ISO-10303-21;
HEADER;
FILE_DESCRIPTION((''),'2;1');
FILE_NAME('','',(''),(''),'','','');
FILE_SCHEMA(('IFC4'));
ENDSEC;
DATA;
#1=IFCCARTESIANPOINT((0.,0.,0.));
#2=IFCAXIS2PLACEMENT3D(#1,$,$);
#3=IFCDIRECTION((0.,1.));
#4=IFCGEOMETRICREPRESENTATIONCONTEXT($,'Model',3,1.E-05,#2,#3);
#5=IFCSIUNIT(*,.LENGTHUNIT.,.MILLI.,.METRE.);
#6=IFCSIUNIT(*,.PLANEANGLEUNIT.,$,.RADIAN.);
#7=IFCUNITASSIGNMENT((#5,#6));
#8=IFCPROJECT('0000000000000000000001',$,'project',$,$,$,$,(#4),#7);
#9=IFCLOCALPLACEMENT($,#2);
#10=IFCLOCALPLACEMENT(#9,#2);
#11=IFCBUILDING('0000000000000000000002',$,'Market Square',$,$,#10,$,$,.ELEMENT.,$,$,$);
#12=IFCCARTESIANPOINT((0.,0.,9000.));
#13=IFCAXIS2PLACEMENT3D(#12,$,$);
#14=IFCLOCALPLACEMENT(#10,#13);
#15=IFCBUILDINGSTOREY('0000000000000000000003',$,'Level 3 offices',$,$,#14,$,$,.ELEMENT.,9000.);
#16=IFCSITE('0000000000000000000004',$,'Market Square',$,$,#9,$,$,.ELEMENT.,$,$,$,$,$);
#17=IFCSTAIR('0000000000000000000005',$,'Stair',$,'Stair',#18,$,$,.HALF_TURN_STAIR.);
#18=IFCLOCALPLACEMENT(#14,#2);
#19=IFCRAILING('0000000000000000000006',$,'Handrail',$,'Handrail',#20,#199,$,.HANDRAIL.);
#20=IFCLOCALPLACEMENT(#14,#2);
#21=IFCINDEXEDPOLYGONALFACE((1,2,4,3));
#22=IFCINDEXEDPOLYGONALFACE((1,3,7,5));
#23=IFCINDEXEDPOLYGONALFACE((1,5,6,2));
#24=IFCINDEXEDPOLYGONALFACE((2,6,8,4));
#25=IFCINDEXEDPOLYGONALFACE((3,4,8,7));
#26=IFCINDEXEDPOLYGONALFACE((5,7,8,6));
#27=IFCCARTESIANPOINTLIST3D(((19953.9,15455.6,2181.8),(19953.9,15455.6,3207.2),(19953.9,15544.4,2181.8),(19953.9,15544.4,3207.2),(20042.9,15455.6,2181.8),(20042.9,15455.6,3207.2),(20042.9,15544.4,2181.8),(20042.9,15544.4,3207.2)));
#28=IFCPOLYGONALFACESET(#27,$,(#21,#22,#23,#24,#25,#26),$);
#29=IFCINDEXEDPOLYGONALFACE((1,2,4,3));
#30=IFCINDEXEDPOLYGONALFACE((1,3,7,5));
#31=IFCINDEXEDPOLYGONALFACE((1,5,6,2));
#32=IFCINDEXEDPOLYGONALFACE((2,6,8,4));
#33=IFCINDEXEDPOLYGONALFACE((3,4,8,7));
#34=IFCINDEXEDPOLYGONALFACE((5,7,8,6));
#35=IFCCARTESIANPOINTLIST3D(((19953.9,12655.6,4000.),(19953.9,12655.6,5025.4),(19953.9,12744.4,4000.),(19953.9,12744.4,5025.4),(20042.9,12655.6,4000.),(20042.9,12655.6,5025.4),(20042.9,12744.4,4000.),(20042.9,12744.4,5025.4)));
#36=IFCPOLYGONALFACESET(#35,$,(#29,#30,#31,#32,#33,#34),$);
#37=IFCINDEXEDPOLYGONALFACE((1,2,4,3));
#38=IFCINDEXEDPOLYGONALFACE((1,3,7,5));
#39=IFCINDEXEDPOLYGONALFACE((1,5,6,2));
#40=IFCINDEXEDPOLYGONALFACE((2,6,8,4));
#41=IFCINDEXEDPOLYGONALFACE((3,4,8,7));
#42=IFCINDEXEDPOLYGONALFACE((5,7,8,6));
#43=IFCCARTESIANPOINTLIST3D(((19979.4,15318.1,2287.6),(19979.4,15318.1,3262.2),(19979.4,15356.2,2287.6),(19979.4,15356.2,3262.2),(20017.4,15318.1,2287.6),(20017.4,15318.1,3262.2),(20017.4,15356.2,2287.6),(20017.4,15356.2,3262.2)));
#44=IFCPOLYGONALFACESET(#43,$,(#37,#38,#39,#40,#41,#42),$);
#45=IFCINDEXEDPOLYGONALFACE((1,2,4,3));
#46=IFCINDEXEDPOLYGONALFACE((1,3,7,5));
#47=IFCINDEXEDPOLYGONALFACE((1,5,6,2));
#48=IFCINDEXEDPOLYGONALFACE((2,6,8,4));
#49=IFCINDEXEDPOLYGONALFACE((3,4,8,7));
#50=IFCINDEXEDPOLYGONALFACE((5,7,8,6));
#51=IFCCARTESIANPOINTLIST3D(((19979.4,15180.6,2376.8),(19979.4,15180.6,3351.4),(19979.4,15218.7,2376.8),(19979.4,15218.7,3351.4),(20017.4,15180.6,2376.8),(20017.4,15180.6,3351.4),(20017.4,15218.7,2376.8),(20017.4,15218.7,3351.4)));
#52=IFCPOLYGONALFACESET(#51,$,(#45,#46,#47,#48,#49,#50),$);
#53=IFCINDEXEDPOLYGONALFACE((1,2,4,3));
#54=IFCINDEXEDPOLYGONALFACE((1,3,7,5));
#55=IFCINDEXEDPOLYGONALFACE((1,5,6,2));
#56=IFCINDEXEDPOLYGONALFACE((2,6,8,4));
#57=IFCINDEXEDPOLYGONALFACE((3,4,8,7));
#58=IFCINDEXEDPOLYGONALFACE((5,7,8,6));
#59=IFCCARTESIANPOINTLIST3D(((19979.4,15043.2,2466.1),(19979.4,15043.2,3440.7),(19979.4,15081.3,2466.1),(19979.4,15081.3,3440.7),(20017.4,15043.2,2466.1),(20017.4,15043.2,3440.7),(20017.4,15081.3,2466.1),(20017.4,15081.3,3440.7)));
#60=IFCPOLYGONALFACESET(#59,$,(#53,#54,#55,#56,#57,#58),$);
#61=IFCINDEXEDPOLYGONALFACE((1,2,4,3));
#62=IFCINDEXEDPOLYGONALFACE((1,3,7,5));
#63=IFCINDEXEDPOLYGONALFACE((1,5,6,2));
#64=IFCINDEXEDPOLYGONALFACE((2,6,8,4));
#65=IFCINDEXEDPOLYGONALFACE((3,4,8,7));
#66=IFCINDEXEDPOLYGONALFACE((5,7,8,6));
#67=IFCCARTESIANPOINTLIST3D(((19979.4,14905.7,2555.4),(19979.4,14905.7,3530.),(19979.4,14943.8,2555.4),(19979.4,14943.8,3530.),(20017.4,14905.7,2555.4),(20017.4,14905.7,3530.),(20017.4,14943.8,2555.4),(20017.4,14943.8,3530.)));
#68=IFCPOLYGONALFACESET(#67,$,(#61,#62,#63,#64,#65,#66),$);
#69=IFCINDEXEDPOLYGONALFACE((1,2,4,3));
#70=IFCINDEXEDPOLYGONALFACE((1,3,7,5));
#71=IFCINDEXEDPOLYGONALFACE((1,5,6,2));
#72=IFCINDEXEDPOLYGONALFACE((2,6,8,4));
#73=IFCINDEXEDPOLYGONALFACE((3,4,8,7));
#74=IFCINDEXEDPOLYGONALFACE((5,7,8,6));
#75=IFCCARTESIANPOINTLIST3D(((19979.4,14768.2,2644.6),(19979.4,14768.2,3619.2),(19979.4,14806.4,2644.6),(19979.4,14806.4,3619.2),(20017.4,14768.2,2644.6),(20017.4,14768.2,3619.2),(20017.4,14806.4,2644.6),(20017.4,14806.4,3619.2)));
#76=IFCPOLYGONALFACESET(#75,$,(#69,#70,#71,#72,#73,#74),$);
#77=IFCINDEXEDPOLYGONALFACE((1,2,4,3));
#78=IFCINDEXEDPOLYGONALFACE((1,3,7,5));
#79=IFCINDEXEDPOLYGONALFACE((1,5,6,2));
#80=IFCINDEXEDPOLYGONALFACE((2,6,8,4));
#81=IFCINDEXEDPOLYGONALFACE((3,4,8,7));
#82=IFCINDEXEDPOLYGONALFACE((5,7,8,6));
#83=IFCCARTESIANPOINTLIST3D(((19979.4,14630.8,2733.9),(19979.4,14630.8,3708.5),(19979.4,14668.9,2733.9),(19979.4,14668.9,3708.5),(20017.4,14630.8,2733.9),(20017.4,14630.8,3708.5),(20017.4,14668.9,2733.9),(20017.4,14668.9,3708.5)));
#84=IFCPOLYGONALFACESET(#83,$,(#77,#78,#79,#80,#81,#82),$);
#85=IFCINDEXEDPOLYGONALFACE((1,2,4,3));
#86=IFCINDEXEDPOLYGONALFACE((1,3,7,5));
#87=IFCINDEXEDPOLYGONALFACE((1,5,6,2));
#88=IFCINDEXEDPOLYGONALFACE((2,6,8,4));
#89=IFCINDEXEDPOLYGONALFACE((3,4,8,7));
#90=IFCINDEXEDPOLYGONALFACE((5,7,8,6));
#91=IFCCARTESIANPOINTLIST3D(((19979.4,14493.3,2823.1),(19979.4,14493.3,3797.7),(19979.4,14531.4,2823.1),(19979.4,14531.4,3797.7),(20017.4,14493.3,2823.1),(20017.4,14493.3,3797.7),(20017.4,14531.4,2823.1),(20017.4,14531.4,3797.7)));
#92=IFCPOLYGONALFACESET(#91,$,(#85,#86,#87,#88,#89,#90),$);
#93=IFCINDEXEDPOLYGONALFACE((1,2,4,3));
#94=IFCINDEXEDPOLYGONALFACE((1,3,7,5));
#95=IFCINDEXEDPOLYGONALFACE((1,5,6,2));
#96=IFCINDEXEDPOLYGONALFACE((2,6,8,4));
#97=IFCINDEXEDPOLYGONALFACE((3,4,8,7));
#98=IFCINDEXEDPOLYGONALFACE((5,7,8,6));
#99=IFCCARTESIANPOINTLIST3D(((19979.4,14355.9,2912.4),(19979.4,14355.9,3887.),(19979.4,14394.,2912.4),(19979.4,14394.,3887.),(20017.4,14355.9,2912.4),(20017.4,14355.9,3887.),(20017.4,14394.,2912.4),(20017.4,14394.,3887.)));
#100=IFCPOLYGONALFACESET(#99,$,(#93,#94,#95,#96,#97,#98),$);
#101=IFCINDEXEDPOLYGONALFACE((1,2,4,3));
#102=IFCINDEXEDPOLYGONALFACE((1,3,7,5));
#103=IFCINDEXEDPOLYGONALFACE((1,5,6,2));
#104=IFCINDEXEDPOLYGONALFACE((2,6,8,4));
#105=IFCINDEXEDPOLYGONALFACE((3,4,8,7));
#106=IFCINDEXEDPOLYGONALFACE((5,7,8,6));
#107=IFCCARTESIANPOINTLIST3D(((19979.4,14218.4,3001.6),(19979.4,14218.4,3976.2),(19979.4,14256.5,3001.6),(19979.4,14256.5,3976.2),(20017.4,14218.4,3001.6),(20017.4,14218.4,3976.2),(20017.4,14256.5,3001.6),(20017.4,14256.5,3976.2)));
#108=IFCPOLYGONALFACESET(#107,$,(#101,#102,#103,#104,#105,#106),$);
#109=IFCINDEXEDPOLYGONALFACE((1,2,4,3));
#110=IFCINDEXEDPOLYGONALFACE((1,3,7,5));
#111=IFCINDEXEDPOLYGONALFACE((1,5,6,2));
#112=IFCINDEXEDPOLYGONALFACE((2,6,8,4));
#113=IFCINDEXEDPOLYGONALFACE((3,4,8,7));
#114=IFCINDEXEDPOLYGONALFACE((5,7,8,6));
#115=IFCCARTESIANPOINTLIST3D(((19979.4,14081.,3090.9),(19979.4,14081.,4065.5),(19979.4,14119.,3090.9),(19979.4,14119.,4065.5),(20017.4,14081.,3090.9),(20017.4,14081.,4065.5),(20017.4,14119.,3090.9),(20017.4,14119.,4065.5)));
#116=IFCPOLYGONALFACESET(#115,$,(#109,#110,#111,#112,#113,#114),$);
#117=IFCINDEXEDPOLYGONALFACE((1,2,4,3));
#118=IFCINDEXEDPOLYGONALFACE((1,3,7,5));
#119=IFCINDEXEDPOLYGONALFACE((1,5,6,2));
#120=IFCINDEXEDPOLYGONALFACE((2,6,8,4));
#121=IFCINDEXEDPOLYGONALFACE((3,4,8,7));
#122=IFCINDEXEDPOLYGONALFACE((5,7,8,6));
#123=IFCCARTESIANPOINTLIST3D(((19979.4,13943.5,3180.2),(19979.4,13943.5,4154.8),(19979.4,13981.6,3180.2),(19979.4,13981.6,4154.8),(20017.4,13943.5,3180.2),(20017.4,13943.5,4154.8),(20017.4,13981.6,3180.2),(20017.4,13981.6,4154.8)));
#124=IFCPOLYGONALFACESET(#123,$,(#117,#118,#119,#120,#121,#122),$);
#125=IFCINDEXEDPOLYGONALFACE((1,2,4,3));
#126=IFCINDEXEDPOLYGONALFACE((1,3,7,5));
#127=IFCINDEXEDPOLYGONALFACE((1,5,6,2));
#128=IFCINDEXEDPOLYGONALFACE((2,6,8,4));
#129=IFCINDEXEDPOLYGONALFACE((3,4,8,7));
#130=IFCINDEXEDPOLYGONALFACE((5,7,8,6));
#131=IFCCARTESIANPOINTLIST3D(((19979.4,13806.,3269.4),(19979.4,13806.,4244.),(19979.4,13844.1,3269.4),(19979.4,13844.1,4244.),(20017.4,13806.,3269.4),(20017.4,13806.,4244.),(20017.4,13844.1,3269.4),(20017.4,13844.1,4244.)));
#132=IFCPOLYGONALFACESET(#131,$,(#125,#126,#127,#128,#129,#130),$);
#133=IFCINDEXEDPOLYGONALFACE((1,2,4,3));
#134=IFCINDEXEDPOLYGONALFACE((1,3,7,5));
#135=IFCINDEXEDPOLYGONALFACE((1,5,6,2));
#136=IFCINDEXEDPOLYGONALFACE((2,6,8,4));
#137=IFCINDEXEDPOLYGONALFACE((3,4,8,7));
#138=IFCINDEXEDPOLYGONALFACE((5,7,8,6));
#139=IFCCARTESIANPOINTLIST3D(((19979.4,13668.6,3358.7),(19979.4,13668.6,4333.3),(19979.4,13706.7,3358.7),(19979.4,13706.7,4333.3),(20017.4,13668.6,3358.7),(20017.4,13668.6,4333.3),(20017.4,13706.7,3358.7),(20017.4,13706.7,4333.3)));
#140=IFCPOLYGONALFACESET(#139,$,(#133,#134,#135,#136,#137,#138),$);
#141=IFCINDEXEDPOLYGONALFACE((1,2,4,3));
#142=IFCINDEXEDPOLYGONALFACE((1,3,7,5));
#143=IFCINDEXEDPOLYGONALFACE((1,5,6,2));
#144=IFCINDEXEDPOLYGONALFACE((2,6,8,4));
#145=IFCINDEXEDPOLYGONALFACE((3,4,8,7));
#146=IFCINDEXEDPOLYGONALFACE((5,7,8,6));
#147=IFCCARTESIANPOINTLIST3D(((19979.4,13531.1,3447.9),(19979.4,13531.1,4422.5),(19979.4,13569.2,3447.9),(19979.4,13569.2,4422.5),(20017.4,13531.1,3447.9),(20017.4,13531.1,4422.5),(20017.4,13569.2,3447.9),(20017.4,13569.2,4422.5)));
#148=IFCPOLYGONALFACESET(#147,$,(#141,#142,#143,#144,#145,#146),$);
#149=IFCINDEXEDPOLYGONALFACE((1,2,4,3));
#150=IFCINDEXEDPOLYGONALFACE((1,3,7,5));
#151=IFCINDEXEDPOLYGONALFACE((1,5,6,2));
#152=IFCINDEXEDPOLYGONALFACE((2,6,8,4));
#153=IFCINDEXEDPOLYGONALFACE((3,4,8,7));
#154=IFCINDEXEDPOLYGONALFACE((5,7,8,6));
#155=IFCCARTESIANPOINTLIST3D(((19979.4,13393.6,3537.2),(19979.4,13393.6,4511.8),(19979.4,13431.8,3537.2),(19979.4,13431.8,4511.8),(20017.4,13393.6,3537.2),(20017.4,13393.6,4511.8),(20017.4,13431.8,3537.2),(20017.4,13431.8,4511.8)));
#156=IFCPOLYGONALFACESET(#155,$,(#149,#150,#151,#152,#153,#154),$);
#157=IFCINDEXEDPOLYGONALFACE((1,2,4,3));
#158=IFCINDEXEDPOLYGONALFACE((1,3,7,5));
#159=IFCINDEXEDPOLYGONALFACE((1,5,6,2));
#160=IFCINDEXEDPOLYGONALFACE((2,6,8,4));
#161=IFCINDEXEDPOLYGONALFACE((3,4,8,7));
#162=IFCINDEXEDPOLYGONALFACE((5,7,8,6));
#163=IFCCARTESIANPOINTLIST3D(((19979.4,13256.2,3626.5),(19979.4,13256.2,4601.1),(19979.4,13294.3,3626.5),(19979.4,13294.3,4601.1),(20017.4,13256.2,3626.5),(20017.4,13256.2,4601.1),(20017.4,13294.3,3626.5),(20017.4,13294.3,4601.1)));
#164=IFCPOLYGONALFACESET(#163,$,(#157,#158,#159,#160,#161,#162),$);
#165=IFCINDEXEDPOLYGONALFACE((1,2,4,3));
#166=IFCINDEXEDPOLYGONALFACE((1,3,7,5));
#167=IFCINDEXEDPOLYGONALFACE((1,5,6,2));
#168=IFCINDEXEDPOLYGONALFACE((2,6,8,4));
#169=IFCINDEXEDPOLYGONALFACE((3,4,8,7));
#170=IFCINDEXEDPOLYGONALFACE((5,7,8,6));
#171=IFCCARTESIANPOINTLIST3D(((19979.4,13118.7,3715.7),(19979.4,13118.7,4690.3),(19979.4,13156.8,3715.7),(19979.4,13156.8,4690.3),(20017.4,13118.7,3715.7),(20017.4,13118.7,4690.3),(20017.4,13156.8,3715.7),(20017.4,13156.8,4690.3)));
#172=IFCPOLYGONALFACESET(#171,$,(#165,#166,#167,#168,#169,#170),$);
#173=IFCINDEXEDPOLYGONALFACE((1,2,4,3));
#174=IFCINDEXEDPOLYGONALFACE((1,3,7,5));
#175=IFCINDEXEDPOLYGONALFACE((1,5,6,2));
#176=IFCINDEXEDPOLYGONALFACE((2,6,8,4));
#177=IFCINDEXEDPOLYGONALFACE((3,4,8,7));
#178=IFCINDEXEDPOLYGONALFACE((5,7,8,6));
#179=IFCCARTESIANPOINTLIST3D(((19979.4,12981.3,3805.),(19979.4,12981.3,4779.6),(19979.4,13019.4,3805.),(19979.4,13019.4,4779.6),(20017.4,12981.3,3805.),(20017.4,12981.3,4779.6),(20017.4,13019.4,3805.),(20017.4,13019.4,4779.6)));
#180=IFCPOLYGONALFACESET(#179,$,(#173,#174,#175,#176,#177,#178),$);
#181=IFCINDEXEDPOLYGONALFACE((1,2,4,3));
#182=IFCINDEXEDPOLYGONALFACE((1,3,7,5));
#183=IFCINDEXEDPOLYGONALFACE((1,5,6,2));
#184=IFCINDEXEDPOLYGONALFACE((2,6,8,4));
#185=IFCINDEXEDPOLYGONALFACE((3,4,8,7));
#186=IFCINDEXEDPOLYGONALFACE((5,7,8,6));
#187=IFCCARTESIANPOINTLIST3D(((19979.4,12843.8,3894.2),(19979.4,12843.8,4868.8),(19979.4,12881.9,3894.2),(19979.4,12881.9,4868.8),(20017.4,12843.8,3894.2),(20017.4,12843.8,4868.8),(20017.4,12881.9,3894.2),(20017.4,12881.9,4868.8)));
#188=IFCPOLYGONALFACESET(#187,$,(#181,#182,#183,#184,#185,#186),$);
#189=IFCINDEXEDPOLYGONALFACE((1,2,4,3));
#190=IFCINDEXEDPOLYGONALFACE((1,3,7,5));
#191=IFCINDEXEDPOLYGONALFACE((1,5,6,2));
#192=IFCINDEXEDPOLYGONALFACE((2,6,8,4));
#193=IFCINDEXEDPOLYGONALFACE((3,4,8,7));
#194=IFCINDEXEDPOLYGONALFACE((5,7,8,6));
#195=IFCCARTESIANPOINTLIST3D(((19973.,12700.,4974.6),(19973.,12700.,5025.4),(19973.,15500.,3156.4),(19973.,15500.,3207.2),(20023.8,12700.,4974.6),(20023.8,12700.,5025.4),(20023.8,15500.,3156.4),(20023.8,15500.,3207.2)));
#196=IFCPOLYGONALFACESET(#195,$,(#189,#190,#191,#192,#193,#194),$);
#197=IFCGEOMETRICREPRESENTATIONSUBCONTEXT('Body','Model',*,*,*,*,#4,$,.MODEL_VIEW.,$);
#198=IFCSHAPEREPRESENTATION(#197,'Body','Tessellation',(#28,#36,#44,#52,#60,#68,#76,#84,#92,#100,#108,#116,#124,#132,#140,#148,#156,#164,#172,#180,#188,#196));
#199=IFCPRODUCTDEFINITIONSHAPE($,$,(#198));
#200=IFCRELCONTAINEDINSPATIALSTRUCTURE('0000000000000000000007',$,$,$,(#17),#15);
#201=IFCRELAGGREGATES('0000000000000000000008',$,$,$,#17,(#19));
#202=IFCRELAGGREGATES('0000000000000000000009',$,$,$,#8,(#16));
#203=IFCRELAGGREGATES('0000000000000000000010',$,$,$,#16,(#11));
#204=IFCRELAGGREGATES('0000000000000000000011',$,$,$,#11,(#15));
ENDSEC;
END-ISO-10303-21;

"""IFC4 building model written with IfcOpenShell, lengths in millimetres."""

from ifc_helpers import new_model, si_unit, direction, frame, origin, origin_with_axes, place, context, subcontext, project, spatial, polyline, outline, extrude, element, aggregate, save


model = new_model("IFC4")

# Units and contexts
model_context = context("Model", 3, precision=1e-05, world=origin(), true_north=direction((0.0, 1.0)))
body_context = subcontext(model_context, "Body", "Model", "MODEL_VIEW")
ifc_project = project(units=[si_unit("LENGTHUNIT", "METRE", prefix="MILLI"), si_unit("PLANEANGLEUNIT", "RADIAN")], contexts=[model_context])

# Site, building, storey
site_placement = place(None, origin())
site = spatial("IfcSite", under=ifc_project, at=site_placement, Name="Market Square", CompositionType="ELEMENT")
building_placement = place(site_placement, origin())
building = spatial("IfcBuilding", under=site, at=building_placement, Name="Market Square", CompositionType="ELEMENT")
storey_placement = place(building_placement, frame((0.0, 0.0, 9000.0)))
storey = spatial("IfcBuildingStorey", under=building, at=storey_placement, Name="Level 3 offices", CompositionType="ELEMENT", Elevation=9000.0)

# Stair, railing
stair_placement = place(storey_placement, origin_with_axes())
stair = element("IfcStair", 1, at=stair_placement, inside=storey, Name="Stair", ObjectType="Stair", PredefinedType="HALF_TURN_STAIR")
railing_1_placement = place(storey_placement, origin_with_axes())
railing_1 = element("IfcRailing", 2, at=railing_1_placement, Name="Handrail", ObjectType="Handrail", PredefinedType="HANDRAIL", context=body_context, shape_type="SweptSolid", body=[
    extrude(outline(polyline([(-44.5, -44.5), (44.5, -44.5), (44.5, 44.5), (-44.5, 44.5), (-44.5, -44.5)])), frame((19998.4, 15500.0, 2181.8), z_axis=(0.0, 0.0, 1.0), x_axis=(1.0, 0.0, 0.0)), (0.0, 0.0, 1.0), 1025.4),
    extrude(outline(polyline([(-44.5, -44.5), (44.5, -44.5), (44.5, 44.5), (-44.5, 44.5), (-44.5, -44.5)])), frame((19998.4, 12700.0, 4000.0), z_axis=(0.0, 0.0, 1.0), x_axis=(1.0, 0.0, 0.0)), (0.0, 0.0, 1.0), 1025.4),
    extrude(outline(polyline([(-19.1, -19.1), (19.1, -19.1), (19.1, 19.1), (-19.1, 19.1), (-19.1, -19.1)])), frame((19998.4, 15337.1, 2287.6), z_axis=(0.0, 0.0, 1.0), x_axis=(1.0, 0.0, 0.0)), (0.0, 0.0, 1.0), 974.6),
    extrude(outline(polyline([(-19.1, -19.1), (19.1, -19.1), (19.1, 19.1), (-19.1, 19.1), (-19.1, -19.1)])), frame((19998.4, 15199.7, 2376.8), z_axis=(0.0, 0.0, 1.0), x_axis=(1.0, 0.0, 0.0)), (0.0, 0.0, 1.0), 974.6),
    extrude(outline(polyline([(-19.1, -19.1), (19.1, -19.1), (19.1, 19.1), (-19.1, 19.1), (-19.1, -19.1)])), frame((19998.4, 15062.2, 2466.1), z_axis=(0.0, 0.0, 1.0), x_axis=(1.0, 0.0, 0.0)), (0.0, 0.0, 1.0), 974.6),
    extrude(outline(polyline([(-19.1, -19.1), (19.1, -19.1), (19.1, 19.1), (-19.1, 19.1), (-19.1, -19.1)])), frame((19998.4, 14924.8, 2555.4), z_axis=(0.0, 0.0, 1.0), x_axis=(1.0, 0.0, 0.0)), (0.0, 0.0, 1.0), 974.6),
    extrude(outline(polyline([(-19.1, -19.1), (19.1, -19.1), (19.1, 19.1), (-19.1, 19.1), (-19.1, -19.1)])), frame((19998.4, 14787.3, 2644.6), z_axis=(0.0, 0.0, 1.0), x_axis=(1.0, 0.0, 0.0)), (0.0, 0.0, 1.0), 974.6),
    extrude(outline(polyline([(-19.1, -19.1), (19.1, -19.1), (19.1, 19.1), (-19.1, 19.1), (-19.1, -19.1)])), frame((19998.4, 14649.8, 2733.9), z_axis=(0.0, 0.0, 1.0), x_axis=(1.0, 0.0, 0.0)), (0.0, 0.0, 1.0), 974.6),
    extrude(outline(polyline([(-19.1, -19.1), (19.1, -19.1), (19.1, 19.1), (-19.1, 19.1), (-19.1, -19.1)])), frame((19998.4, 14512.4, 2823.1), z_axis=(0.0, 0.0, 1.0), x_axis=(1.0, 0.0, 0.0)), (0.0, 0.0, 1.0), 974.6),
    extrude(outline(polyline([(-19.1, -19.1), (19.1, -19.1), (19.1, 19.1), (-19.1, 19.1), (-19.1, -19.1)])), frame((19998.4, 14374.9, 2912.4), z_axis=(0.0, 0.0, 1.0), x_axis=(1.0, 0.0, 0.0)), (0.0, 0.0, 1.0), 974.6),
    extrude(outline(polyline([(-19.1, -19.1), (19.1, -19.1), (19.1, 19.1), (-19.1, 19.1), (-19.1, -19.1)])), frame((19998.4, 14237.5, 3001.6), z_axis=(0.0, 0.0, 1.0), x_axis=(1.0, 0.0, 0.0)), (0.0, 0.0, 1.0), 974.6),
    extrude(outline(polyline([(-19.1, -19.1), (19.1, -19.1), (19.1, 19.1), (-19.1, 19.1), (-19.1, -19.1)])), frame((19998.4, 14100.0, 3090.9), z_axis=(0.0, 0.0, 1.0), x_axis=(1.0, 0.0, 0.0)), (0.0, 0.0, 1.0), 974.6),
    extrude(outline(polyline([(-19.1, -19.1), (19.1, -19.1), (19.1, 19.1), (-19.1, 19.1), (-19.1, -19.1)])), frame((19998.4, 13962.5, 3180.2), z_axis=(0.0, 0.0, 1.0), x_axis=(1.0, 0.0, 0.0)), (0.0, 0.0, 1.0), 974.6),
    extrude(outline(polyline([(-19.1, -19.1), (19.1, -19.1), (19.1, 19.1), (-19.1, 19.1), (-19.1, -19.1)])), frame((19998.4, 13825.1, 3269.4), z_axis=(0.0, 0.0, 1.0), x_axis=(1.0, 0.0, 0.0)), (0.0, 0.0, 1.0), 974.6),
    extrude(outline(polyline([(-19.1, -19.1), (19.1, -19.1), (19.1, 19.1), (-19.1, 19.1), (-19.1, -19.1)])), frame((19998.4, 13687.6, 3358.7), z_axis=(0.0, 0.0, 1.0), x_axis=(1.0, 0.0, 0.0)), (0.0, 0.0, 1.0), 974.6),
    extrude(outline(polyline([(-19.1, -19.1), (19.1, -19.1), (19.1, 19.1), (-19.1, 19.1), (-19.1, -19.1)])), frame((19998.4, 13550.2, 3447.9), z_axis=(0.0, 0.0, 1.0), x_axis=(1.0, 0.0, 0.0)), (0.0, 0.0, 1.0), 974.6),
    extrude(outline(polyline([(-19.1, -19.1), (19.1, -19.1), (19.1, 19.1), (-19.1, 19.1), (-19.1, -19.1)])), frame((19998.4, 13412.7, 3537.2), z_axis=(0.0, 0.0, 1.0), x_axis=(1.0, 0.0, 0.0)), (0.0, 0.0, 1.0), 974.6),
    extrude(outline(polyline([(-19.1, -19.1), (19.1, -19.1), (19.1, 19.1), (-19.1, 19.1), (-19.1, -19.1)])), frame((19998.4, 13275.2, 3626.5), z_axis=(0.0, 0.0, 1.0), x_axis=(1.0, 0.0, 0.0)), (0.0, 0.0, 1.0), 974.6),
    extrude(outline(polyline([(-19.1, -19.1), (19.1, -19.1), (19.1, 19.1), (-19.1, 19.1), (-19.1, -19.1)])), frame((19998.4, 13137.8, 3715.7), z_axis=(0.0, 0.0, 1.0), x_axis=(1.0, 0.0, 0.0)), (0.0, 0.0, 1.0), 974.6),
    extrude(outline(polyline([(-19.1, -19.1), (19.1, -19.1), (19.1, 19.1), (-19.1, 19.1), (-19.1, -19.1)])), frame((19998.4, 13000.3, 3805.0), z_axis=(0.0, 0.0, 1.0), x_axis=(1.0, 0.0, 0.0)), (0.0, 0.0, 1.0), 974.6),
    extrude(outline(polyline([(-19.1, -19.1), (19.1, -19.1), (19.1, 19.1), (-19.1, 19.1), (-19.1, -19.1)])), frame((19998.4, 12862.9, 3894.2), z_axis=(0.0, 0.0, 1.0), x_axis=(1.0, 0.0, 0.0)), (0.0, 0.0, 1.0), 974.6),
    extrude(outline(polyline([(0.0, 0.0), (50.8, 0.0), (50.8, 50.8), (0.0, 50.8), (0.0, 0.0)])), frame((19973.0, 15500.0, 3156.4), z_axis=(0.0, -1.0, 0.0), x_axis=(1.0, 0.0, 0.0)), (0.0, 0.544605, 0.838692), 3338.5),
])
aggregate(stair, [railing_1])

save(model, "model.ifc")
